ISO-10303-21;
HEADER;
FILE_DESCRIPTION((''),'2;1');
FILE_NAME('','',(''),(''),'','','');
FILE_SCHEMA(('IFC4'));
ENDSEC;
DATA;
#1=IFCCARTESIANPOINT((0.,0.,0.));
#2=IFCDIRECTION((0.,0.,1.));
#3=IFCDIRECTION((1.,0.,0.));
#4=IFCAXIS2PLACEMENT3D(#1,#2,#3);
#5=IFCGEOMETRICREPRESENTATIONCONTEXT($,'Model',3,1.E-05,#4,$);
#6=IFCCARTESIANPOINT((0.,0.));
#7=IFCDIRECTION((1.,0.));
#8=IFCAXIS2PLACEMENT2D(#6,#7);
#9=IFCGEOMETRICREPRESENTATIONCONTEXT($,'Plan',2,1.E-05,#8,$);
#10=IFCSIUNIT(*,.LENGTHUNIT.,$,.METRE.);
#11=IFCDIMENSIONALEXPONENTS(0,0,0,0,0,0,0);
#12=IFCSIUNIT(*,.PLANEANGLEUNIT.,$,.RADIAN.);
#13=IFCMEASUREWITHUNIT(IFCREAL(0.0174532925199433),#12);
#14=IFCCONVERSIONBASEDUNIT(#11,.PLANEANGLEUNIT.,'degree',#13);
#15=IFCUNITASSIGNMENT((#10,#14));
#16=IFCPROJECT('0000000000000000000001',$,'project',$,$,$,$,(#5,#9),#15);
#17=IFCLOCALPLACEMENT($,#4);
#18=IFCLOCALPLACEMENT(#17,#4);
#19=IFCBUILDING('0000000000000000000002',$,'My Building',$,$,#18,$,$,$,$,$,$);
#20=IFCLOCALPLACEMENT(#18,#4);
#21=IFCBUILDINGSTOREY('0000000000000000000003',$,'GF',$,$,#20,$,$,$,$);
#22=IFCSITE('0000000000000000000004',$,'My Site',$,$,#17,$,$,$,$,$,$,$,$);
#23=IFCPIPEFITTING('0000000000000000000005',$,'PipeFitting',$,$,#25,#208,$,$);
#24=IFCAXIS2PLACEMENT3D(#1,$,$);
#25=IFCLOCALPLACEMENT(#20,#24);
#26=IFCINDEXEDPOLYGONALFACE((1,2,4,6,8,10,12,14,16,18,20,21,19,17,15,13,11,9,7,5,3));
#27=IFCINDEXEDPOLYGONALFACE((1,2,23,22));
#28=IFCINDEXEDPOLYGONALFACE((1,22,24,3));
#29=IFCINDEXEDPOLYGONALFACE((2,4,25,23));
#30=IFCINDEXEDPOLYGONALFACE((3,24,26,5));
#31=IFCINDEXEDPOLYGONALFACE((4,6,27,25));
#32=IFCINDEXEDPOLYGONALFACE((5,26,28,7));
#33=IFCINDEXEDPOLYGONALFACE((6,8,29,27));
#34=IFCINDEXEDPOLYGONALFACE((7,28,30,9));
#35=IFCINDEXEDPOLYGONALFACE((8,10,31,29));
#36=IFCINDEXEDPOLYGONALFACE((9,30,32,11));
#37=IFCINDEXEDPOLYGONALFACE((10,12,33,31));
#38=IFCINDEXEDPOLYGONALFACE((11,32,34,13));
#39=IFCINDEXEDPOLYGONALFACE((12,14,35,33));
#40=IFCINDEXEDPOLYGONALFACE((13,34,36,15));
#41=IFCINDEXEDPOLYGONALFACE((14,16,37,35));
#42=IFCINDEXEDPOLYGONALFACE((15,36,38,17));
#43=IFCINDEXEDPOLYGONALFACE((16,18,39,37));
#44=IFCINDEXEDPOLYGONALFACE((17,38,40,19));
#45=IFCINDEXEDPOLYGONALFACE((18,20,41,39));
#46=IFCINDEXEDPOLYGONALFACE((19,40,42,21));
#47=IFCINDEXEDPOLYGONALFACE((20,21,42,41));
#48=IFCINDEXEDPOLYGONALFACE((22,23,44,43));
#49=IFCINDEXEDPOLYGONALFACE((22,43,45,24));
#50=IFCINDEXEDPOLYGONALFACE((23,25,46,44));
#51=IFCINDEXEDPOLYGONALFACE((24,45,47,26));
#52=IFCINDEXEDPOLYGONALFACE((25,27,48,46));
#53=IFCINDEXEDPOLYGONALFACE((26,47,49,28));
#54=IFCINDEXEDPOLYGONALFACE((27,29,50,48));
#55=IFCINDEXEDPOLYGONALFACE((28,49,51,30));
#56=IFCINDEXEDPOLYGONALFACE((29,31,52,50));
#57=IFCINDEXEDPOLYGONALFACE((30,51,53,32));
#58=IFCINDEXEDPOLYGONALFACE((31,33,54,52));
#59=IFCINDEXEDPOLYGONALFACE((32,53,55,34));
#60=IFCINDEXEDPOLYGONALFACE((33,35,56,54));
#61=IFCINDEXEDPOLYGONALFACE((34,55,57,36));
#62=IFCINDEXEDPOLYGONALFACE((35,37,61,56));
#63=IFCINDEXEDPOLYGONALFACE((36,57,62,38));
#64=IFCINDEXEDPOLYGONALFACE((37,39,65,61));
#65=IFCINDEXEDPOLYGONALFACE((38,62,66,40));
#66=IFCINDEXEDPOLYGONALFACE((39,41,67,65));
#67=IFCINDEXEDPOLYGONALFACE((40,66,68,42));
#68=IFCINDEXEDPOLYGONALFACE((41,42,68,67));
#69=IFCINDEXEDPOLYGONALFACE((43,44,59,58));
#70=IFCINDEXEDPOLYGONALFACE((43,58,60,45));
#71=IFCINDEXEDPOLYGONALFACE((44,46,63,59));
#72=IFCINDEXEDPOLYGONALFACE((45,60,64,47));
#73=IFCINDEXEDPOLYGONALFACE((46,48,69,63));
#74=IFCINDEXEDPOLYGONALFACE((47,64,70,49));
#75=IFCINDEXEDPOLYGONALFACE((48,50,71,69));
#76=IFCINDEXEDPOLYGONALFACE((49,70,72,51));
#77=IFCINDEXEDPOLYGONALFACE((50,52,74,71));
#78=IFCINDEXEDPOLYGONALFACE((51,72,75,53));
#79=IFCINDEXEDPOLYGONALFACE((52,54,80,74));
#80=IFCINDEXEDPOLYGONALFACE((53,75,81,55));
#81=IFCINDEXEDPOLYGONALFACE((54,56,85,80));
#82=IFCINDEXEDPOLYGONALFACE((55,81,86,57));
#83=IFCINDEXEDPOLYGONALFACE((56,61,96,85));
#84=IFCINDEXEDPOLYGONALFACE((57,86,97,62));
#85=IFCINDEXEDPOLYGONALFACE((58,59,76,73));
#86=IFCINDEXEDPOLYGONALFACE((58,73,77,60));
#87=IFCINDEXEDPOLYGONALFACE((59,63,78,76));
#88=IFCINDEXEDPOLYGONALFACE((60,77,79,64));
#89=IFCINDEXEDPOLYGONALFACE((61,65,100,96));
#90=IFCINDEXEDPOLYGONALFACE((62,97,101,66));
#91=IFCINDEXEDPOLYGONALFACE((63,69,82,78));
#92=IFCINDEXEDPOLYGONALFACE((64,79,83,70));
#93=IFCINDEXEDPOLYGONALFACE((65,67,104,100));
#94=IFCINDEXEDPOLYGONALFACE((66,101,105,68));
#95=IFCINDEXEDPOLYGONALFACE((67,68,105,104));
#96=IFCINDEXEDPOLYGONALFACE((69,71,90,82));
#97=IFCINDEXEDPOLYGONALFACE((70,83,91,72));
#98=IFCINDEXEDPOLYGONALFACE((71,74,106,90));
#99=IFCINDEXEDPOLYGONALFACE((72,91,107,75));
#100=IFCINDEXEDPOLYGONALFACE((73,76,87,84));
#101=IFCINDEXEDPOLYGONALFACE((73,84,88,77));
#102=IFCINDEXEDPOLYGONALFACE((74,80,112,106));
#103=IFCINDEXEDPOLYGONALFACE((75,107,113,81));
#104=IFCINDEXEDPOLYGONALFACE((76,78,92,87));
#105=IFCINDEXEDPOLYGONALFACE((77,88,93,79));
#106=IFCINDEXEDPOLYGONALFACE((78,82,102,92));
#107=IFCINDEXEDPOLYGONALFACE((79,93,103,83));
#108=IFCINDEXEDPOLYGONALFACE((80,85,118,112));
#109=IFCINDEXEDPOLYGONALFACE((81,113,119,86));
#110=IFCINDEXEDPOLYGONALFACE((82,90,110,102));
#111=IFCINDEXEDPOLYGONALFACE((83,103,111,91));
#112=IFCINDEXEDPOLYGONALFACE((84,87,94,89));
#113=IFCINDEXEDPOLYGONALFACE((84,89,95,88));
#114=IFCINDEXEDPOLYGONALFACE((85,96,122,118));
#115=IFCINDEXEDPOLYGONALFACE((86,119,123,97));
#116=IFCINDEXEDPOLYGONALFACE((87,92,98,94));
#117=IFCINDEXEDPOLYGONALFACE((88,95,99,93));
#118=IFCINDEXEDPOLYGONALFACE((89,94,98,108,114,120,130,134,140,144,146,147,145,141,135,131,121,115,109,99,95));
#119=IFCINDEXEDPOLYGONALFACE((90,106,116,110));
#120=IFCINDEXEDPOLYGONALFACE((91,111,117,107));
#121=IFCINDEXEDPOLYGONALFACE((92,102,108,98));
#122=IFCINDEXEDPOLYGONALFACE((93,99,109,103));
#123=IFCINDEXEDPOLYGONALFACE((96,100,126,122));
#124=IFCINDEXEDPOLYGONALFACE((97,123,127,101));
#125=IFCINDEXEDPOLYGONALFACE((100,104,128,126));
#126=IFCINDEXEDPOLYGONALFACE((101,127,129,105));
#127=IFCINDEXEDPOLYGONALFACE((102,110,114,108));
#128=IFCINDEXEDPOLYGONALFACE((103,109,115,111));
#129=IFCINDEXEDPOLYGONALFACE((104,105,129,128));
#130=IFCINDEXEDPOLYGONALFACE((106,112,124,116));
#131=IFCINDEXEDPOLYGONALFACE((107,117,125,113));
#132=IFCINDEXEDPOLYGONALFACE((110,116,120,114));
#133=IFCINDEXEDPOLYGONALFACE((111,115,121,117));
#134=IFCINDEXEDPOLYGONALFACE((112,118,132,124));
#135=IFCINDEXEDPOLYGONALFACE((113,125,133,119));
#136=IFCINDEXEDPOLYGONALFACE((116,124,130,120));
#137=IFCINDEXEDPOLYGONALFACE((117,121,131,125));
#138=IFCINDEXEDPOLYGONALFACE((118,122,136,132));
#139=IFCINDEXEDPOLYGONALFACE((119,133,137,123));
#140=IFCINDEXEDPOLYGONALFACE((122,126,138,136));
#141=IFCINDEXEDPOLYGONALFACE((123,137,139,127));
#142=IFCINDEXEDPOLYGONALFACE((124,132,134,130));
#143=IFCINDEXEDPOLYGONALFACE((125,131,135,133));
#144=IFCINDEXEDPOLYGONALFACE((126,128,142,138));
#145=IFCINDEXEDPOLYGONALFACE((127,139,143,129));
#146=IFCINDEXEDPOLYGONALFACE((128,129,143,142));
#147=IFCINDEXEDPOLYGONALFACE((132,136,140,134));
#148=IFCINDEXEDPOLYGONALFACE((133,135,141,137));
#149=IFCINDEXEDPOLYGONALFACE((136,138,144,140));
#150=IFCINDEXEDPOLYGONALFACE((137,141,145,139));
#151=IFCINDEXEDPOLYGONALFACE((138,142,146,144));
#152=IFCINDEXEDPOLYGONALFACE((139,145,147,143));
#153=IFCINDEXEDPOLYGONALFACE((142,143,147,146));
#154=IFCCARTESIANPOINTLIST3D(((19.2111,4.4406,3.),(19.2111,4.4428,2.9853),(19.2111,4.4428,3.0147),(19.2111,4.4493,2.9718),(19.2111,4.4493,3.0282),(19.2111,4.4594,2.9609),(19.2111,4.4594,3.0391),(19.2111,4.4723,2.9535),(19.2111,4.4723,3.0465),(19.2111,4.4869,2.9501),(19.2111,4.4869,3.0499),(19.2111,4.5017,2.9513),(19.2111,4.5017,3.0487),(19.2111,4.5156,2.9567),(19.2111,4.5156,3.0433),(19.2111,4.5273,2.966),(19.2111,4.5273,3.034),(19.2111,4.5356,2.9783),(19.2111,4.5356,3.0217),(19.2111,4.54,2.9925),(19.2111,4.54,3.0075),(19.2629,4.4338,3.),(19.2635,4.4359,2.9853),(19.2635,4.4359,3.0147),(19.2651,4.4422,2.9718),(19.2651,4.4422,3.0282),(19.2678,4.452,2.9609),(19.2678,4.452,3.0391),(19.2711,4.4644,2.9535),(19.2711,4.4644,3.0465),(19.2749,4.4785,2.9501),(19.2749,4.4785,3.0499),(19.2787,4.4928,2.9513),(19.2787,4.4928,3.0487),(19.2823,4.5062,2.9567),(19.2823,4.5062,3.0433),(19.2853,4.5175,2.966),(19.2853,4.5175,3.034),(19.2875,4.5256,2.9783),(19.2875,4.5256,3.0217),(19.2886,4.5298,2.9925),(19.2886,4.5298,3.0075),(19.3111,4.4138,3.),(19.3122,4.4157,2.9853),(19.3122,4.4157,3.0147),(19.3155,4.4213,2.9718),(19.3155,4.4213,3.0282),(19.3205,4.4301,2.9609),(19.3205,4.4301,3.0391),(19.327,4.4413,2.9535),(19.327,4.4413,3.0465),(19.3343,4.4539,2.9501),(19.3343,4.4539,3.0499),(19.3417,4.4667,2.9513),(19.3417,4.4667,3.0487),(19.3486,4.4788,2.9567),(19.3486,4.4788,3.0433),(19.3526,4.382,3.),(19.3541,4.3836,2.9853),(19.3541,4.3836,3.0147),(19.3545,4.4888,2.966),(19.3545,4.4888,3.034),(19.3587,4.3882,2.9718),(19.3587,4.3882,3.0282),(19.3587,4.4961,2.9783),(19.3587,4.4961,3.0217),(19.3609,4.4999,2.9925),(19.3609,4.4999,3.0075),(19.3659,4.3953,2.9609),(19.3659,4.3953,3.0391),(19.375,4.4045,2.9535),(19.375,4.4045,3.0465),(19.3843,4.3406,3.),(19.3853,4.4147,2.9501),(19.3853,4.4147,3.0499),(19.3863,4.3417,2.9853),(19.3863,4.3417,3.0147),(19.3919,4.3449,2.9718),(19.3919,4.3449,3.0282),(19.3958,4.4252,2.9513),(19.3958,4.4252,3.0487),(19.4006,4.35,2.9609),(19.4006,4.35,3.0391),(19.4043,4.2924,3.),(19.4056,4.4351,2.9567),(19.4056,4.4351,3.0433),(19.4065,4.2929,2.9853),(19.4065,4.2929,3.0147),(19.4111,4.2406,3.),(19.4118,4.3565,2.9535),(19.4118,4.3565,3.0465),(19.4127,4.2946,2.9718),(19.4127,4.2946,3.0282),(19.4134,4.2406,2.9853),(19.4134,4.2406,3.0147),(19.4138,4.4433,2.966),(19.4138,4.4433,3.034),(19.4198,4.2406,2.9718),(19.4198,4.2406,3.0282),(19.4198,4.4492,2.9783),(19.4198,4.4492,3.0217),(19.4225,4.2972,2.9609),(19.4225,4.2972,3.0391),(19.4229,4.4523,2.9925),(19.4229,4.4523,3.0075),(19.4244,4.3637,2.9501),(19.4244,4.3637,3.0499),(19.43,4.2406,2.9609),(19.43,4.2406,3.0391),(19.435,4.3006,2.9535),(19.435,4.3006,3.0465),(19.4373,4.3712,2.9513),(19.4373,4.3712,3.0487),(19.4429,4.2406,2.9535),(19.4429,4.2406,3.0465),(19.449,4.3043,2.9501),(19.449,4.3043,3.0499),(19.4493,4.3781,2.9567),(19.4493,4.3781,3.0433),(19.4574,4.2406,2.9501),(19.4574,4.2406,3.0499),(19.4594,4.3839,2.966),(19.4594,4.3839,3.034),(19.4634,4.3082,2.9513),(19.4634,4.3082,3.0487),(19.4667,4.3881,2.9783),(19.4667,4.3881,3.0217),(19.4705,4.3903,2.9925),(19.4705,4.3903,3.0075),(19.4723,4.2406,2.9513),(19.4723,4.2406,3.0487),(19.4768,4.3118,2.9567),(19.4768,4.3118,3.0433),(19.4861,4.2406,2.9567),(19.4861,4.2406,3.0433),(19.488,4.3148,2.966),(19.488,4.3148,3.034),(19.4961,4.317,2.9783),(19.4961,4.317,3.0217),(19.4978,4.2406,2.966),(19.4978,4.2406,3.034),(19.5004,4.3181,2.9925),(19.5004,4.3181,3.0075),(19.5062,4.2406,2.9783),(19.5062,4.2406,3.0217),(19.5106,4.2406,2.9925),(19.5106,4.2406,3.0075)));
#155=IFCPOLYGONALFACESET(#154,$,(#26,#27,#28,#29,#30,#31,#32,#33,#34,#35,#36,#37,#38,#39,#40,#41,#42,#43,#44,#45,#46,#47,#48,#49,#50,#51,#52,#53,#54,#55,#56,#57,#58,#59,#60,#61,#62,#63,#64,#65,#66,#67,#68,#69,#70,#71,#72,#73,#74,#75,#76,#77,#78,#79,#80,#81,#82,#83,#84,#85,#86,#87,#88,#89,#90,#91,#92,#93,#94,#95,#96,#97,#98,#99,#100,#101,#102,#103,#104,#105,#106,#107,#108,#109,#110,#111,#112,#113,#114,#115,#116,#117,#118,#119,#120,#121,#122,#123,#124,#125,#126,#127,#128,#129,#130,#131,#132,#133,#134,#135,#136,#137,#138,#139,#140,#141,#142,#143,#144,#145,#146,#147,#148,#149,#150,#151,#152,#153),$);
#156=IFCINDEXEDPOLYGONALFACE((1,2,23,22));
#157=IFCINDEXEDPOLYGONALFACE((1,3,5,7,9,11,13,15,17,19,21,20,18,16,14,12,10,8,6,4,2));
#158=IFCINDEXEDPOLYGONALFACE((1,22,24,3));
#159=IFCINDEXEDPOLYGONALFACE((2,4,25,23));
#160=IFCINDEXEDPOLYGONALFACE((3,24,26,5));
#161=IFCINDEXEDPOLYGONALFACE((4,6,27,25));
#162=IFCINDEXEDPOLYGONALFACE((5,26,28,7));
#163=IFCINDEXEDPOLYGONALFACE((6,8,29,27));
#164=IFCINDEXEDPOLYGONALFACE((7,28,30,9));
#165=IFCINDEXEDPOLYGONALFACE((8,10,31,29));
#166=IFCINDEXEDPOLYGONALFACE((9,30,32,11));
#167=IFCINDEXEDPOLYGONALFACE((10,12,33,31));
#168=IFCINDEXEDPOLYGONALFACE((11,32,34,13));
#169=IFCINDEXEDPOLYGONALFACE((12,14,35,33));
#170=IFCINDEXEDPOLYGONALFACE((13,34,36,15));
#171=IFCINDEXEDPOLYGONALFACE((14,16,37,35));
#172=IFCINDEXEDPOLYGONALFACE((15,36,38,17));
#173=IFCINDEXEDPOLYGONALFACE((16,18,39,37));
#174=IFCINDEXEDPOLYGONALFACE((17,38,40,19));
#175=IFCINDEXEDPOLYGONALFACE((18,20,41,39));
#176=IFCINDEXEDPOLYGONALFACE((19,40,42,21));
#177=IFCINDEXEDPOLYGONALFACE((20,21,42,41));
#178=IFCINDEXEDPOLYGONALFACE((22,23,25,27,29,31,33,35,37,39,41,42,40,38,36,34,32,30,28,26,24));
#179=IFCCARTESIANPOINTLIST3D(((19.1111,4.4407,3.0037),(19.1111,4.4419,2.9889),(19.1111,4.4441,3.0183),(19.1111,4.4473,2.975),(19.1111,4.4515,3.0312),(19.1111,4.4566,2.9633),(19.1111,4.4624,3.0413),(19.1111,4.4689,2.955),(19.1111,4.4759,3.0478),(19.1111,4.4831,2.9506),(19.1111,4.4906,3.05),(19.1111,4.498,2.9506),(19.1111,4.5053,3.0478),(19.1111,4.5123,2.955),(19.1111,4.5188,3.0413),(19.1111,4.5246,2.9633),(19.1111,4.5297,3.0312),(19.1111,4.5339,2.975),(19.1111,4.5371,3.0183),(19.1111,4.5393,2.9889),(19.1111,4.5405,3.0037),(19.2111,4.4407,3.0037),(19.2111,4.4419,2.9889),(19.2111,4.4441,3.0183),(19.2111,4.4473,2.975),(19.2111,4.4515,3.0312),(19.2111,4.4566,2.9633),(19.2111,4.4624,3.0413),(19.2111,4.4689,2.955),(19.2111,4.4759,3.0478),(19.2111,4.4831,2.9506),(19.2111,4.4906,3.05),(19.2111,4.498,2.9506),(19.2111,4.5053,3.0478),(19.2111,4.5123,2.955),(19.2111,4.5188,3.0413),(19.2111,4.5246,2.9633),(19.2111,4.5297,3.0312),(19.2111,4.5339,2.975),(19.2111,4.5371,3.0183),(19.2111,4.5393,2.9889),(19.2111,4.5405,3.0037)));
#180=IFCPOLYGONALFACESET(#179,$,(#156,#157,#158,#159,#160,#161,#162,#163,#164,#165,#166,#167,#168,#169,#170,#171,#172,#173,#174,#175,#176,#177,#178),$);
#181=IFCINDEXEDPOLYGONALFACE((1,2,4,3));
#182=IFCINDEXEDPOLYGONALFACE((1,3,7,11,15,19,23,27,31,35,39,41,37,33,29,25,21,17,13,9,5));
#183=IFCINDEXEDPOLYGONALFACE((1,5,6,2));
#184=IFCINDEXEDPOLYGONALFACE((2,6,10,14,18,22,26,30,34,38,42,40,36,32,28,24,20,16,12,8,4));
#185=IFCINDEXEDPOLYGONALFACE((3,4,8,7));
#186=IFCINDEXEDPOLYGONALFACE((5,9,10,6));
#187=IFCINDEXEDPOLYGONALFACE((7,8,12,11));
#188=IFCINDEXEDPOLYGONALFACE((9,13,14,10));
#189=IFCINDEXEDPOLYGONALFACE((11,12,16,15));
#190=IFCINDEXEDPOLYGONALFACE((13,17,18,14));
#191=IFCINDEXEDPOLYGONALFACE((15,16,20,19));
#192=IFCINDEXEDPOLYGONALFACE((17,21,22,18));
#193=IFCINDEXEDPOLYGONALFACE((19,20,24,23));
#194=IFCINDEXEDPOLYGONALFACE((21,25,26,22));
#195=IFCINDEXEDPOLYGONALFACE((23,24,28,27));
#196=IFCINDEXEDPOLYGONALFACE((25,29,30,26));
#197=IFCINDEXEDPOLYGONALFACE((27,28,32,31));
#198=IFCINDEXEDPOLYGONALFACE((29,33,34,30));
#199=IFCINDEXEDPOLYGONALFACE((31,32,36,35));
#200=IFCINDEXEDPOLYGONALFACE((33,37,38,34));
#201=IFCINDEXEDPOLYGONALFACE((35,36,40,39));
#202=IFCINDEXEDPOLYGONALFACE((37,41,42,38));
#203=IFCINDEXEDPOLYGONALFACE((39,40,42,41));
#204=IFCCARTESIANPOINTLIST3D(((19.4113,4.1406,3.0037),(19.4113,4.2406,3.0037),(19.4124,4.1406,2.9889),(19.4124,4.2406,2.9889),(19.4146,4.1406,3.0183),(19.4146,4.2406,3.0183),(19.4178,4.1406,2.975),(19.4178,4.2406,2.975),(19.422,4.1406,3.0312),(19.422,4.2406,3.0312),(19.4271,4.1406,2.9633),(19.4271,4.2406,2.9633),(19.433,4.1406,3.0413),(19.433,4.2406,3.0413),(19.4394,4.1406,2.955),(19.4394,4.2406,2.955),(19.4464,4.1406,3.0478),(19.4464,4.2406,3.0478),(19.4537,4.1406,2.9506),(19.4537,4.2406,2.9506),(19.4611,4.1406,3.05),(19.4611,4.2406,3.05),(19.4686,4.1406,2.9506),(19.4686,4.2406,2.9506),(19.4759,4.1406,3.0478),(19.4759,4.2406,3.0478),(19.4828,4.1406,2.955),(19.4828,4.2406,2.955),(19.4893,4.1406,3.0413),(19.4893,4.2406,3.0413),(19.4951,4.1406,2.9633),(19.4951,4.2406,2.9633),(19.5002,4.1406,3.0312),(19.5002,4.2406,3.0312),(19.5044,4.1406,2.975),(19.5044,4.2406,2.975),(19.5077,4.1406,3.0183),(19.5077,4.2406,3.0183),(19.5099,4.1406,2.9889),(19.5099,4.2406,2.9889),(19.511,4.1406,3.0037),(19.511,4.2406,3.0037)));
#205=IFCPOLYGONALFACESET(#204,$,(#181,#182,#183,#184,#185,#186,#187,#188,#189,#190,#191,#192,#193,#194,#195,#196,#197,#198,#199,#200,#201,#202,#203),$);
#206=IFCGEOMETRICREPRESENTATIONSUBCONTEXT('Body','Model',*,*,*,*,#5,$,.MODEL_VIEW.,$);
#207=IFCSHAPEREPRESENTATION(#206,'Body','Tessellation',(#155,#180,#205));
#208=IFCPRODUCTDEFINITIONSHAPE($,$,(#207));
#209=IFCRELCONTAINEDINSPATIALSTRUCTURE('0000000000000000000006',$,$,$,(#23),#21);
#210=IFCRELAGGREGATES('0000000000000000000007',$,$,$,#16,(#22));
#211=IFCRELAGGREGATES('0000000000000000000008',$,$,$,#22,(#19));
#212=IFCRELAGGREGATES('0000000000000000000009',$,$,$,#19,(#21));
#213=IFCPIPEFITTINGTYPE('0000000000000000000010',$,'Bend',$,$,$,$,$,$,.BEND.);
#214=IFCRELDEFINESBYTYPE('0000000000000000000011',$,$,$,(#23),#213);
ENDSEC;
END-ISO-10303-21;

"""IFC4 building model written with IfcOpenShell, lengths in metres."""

from ifc_helpers import new_model, entity, si_unit, converted_unit, frame, origin_with_axes, origin_2d_with_axis, place, context, subcontext, project, spatial, circle, extrude, source, transform, mapped, type_object, type_shapes, element, save


model = new_model("IFC4")

# Units and contexts
model_context = context("Model", 3, precision=1e-05, world=origin_with_axes())
plan_context = context("Plan", 2, precision=1e-05, world=origin_2d_with_axis())
body_context_1 = subcontext(model_context, "Body", "Model", "MODEL_VIEW")
ifc_project = project(units=[si_unit("LENGTHUNIT", "METRE"), converted_unit("PLANEANGLEUNIT", "degree", entity("IfcReal", 0.0174532925199433), si_unit("PLANEANGLEUNIT", "RADIAN"), dimensions=[0, 0, 0, 0, 0, 0, 0])], contexts=[model_context, plan_context])

# Site, building, storey
site_placement = place(None, origin_with_axes())
site = spatial("IfcSite", under=ifc_project, at=site_placement, Name="My Site")
building_placement = place(site_placement, origin_with_axes())
building = spatial("IfcBuilding", under=site, at=building_placement, Name="My Building")
storey_placement = place(building_placement, origin_with_axes())
storey = spatial("IfcBuildingStorey", under=building, at=storey_placement, Name="GF")

# Pipe fitting
pipe_fitting_type = type_object("IfcPipeFittingType", Name="Bend", PredefinedType="BEND")
shared_shape_1 = source(origin_with_axes(), body_context_1, "Body", "SolidModel", [
    entity("IfcSweptDiskSolid", entity("IfcIndexedPolyCurve", entity("IfcCartesianPointList3D", [[0.0, 0.0, -0.1], [0.0, -0.0732, -0.2768], [0.0, -0.25, -0.35]]), [entity("IfcArcIndex", [1, 2, 3])]), 0.05),
    extrude(circle(Radius=0.05), origin_with_axes(), (0.0, 0.0, -1.0), 0.1),
    extrude(circle(Radius=0.05), frame((0.0, -0.25, -0.35), z_axis=(0.0, -1.0, 0.0), x_axis=(1.0, 0.0, 0.0)), (0.0, 0.0, 1.0), 0.1),
])
type_shapes(pipe_fitting_type, [shared_shape_1])
pipe_fitting_placement = place(storey_placement, frame((19.1111, 4.4906, 3.0), z_axis=(-1.0, 0.0, 0.0), x_axis=(0.0, 0.0, 1.0)))
element("IfcPipeFitting", 1, at=pipe_fitting_placement, inside=storey, type_object=pipe_fitting_type, Name="PipeFitting", context=body_context_1, shape_type="MappedRepresentation", body=[
    mapped(shared_shape_1, transform((0.0, 0.0, 0.0), x_axis=(1.0, 0.0, 0.0), y_axis=(0.0, 1.0, 0.0), z_axis=(0.0, 0.0, 1.0), scale=1.0)),
])

save(model, "model.ifc")
